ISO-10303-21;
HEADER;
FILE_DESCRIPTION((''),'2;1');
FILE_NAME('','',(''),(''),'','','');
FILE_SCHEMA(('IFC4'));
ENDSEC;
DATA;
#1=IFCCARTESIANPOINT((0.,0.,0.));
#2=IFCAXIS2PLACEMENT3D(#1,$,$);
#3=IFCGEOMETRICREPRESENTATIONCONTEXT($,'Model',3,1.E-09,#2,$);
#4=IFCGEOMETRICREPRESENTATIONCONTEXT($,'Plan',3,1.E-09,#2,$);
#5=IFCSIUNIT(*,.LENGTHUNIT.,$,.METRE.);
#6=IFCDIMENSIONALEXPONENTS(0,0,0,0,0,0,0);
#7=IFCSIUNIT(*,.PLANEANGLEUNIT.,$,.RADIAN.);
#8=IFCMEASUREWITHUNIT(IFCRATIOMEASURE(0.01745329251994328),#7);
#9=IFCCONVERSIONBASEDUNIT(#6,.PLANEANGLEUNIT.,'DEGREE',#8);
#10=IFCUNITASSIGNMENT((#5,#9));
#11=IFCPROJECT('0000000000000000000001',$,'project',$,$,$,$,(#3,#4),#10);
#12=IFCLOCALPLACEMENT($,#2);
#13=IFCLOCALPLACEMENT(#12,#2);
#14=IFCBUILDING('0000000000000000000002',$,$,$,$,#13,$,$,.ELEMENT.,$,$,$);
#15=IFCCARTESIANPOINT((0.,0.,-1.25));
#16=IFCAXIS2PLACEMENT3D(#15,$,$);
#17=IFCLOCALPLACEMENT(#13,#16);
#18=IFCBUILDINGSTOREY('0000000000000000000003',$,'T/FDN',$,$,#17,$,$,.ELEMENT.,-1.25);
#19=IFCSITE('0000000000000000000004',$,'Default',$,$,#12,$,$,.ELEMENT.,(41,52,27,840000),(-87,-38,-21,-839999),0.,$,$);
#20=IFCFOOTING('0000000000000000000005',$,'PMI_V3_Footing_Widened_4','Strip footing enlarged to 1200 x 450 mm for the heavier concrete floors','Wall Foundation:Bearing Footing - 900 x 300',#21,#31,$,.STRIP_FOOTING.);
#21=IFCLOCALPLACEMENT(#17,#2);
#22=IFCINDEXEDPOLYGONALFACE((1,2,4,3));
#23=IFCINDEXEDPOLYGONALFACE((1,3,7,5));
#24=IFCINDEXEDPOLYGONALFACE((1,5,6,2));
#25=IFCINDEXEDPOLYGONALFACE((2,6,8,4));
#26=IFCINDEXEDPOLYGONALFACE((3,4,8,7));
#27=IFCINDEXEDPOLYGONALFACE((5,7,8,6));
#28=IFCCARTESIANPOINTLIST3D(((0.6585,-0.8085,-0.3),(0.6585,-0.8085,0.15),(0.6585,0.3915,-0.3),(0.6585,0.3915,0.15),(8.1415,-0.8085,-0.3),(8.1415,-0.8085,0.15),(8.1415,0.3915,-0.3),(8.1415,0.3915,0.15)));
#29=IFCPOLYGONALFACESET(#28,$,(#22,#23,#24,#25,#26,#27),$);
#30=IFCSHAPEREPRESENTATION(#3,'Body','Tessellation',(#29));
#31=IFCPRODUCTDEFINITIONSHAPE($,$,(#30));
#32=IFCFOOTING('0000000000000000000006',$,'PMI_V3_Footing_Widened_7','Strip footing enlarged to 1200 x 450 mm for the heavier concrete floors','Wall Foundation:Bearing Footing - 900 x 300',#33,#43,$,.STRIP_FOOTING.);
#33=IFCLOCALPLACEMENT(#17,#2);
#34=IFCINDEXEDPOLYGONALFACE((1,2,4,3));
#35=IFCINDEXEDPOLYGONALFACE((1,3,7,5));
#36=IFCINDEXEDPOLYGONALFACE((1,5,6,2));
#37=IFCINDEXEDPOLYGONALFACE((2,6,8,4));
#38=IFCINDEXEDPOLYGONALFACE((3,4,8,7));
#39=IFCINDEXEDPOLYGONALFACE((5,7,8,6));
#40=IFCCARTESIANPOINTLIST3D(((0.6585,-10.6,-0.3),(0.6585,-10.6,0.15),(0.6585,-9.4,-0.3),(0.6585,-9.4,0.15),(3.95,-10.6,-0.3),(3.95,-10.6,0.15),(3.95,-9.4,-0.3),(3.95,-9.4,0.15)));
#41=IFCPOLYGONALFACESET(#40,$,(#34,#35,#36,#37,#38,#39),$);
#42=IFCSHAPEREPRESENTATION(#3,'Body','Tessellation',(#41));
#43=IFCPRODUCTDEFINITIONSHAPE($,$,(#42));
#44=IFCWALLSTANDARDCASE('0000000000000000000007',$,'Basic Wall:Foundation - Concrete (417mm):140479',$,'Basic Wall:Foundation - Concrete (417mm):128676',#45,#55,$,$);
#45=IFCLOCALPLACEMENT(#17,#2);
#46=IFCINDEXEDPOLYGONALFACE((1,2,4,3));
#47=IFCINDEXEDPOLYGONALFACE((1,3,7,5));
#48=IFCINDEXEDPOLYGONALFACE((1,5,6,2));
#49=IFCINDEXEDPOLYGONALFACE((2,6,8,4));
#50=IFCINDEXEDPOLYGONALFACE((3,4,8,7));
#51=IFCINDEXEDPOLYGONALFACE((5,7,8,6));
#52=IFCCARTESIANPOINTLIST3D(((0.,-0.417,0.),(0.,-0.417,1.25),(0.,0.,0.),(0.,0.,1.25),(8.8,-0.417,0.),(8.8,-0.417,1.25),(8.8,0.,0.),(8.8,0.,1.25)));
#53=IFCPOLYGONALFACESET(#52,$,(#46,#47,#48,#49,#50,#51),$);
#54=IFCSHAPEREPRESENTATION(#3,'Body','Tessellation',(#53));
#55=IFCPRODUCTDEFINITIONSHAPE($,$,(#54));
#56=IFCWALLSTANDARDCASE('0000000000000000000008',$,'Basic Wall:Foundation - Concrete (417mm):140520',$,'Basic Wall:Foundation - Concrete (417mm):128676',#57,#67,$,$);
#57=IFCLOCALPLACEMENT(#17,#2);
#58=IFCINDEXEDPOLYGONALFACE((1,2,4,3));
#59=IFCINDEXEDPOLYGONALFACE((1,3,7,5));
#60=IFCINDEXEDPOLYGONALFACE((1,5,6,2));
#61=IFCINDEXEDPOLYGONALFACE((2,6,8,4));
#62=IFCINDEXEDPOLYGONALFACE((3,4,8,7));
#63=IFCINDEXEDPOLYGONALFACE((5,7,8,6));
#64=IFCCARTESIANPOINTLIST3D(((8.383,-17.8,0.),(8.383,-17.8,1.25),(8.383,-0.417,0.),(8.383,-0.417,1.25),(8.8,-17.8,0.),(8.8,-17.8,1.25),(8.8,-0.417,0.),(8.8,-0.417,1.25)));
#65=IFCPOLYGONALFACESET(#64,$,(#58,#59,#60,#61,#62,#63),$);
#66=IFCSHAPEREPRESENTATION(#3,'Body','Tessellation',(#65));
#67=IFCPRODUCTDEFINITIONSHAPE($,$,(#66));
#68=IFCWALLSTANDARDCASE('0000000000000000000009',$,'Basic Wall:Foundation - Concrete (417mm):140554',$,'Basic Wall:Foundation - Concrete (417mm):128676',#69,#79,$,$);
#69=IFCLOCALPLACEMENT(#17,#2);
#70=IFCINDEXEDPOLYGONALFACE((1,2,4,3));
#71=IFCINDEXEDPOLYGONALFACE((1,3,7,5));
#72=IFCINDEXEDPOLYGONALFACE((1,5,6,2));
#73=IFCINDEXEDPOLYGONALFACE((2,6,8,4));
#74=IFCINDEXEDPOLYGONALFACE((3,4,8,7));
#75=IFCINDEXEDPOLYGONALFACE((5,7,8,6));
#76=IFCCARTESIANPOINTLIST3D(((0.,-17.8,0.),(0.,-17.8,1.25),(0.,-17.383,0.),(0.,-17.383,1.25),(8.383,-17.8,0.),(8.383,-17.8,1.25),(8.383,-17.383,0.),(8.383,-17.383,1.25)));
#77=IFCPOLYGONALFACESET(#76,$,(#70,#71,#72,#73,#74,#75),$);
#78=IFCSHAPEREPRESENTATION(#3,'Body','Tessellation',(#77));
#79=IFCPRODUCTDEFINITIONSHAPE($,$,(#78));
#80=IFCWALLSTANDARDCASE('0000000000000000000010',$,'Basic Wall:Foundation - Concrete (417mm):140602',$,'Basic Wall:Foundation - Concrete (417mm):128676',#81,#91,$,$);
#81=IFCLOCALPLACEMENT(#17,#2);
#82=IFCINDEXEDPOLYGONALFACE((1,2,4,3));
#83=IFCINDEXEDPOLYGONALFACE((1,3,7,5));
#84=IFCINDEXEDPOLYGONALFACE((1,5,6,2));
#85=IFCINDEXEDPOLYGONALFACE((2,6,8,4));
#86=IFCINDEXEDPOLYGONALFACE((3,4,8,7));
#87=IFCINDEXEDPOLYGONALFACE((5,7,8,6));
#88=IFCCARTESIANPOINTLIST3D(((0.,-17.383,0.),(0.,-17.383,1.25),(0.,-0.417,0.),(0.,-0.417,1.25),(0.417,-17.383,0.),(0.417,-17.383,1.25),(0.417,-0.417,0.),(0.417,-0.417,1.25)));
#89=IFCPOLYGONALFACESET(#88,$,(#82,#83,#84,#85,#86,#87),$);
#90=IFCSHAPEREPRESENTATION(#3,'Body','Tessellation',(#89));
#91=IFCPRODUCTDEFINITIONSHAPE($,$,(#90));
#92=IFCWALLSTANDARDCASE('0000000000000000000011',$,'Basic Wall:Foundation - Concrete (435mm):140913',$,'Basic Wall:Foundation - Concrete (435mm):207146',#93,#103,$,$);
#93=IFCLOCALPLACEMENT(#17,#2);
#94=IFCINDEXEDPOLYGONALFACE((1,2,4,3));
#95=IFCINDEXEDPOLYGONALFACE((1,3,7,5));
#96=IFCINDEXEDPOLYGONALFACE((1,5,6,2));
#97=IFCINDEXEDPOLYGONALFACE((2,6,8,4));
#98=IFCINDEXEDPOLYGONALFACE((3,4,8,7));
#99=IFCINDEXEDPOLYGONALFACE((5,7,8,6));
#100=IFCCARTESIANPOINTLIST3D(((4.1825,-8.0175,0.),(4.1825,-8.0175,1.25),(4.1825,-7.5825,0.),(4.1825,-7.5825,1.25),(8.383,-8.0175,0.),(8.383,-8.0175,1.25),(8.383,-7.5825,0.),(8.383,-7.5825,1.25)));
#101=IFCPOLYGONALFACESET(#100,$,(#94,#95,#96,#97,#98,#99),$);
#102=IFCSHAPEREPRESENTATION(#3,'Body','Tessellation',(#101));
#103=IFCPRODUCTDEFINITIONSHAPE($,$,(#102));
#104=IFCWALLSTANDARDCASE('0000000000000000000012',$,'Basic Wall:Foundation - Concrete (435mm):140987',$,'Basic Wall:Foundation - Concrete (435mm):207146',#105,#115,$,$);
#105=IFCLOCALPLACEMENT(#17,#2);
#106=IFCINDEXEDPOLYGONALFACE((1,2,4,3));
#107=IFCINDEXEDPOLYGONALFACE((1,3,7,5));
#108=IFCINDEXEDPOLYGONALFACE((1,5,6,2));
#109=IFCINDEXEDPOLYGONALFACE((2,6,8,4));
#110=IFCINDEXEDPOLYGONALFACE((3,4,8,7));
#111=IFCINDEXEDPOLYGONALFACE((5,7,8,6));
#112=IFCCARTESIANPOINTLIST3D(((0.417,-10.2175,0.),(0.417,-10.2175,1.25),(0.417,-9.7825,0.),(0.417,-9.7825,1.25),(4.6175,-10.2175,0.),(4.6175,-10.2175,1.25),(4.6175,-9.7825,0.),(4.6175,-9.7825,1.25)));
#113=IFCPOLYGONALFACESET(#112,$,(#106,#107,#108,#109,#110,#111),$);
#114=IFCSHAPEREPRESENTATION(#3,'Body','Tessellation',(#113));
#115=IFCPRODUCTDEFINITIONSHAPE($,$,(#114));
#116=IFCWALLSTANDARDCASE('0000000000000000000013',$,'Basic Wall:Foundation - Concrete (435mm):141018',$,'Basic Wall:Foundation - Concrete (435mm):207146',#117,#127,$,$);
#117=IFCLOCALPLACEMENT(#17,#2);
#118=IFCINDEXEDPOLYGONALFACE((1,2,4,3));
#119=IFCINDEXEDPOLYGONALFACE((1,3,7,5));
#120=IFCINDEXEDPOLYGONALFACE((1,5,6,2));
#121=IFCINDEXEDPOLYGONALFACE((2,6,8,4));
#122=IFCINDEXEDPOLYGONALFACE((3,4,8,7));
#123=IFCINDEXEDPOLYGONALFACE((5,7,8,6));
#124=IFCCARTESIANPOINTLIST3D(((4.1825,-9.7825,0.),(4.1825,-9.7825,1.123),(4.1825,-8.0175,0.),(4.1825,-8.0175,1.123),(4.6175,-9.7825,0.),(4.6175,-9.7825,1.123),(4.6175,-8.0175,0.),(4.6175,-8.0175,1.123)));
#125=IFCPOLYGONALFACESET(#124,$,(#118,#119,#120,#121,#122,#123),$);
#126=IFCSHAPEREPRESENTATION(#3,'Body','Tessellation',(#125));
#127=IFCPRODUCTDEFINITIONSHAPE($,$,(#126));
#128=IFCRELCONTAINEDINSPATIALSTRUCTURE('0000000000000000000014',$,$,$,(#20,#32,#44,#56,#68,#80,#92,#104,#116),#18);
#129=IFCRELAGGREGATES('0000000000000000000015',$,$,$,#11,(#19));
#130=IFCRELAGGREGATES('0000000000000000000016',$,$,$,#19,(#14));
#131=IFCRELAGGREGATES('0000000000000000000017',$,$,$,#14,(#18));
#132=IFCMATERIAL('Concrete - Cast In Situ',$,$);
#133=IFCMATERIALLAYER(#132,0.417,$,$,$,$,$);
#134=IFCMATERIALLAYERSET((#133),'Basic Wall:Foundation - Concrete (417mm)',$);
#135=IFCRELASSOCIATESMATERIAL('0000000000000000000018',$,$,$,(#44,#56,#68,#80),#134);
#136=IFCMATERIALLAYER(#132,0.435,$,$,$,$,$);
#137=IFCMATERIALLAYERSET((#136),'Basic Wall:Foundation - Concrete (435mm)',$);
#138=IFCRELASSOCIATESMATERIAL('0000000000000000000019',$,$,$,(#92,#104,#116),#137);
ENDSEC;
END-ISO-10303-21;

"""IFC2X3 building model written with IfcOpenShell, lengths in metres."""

from ifc_helpers import new_model, entity, si_unit, converted_unit, frame, frame_2d, origin, origin_2d_with_axis, place, context, project, spatial, rectangle, extrude, material, layer, layer_set, layer_usage, element, save


model = new_model("IFC2X3")

# Units and contexts
model_context = context("Model", 3, precision=1e-09, world=origin())
plan_context = context("Plan", 3, precision=1e-09, world=origin())
ifc_project = project(units=[si_unit("LENGTHUNIT", "METRE"), converted_unit("PLANEANGLEUNIT", "DEGREE", entity("IfcRatioMeasure", 0.01745329251994328), si_unit("PLANEANGLEUNIT", "RADIAN"), dimensions=[0, 0, 0, 0, 0, 0, 0])], contexts=[model_context, plan_context])

# Site, building, storey
site_placement = place(None, origin())
site = spatial("IfcSite", under=ifc_project, at=site_placement, Name="Default", CompositionType="ELEMENT", RefLatitude=(41, 52, 27, 840000), RefLongitude=(-87, -38, -21, -839999), RefElevation=0.0)
building_placement = place(site_placement, origin())
building = spatial("IfcBuilding", under=site, at=building_placement, CompositionType="ELEMENT")
storey_placement = place(building_placement, frame((0.0, 0.0, -1.25)))
storey = spatial("IfcBuildingStorey", under=building, at=storey_placement, Name="T/FDN", CompositionType="ELEMENT", Elevation=-1.25)

# Footings
footing_1_placement = place(storey_placement, origin())
element("IfcFooting", 1, at=footing_1_placement, inside=storey, Name="PMI_V3_Footing_Widened_4", Description="Strip footing enlarged to 1200 x 450 mm for the heavier concrete floors", ObjectType="Wall Foundation:Bearing Footing - 900 x 300", PredefinedType="STRIP_FOOTING", context=model_context, shape_type="SweptSolid", body=[
    extrude(rectangle(XDim=7.483, YDim=1.2, at=origin_2d_with_axis()), frame((4.4, -0.2085, -0.3), z_axis=(0.0, 0.0, 1.0), x_axis=(-1.0, 0.0, 0.0)), (0.0, 0.0, 1.0), 0.45),
])
footing_2_placement = place(storey_placement, origin())
element("IfcFooting", 2, at=footing_2_placement, inside=storey, Name="PMI_V3_Footing_Widened_7", Description="Strip footing enlarged to 1200 x 450 mm for the heavier concrete floors", ObjectType="Wall Foundation:Bearing Footing - 900 x 300", PredefinedType="STRIP_FOOTING", context=model_context, shape_type="SweptSolid", body=[
    extrude(rectangle(XDim=3.2915, YDim=1.2, at=origin_2d_with_axis()), frame((2.3042, -10.0, -0.3)), (0.0, 0.0, 1.0), 0.45),
])

# Walls
ifc_material = material(Name="Concrete - Cast In Situ")
ifc_layer_1 = layer(ifc_material, 0.417)
ifc_layer_set_1 = layer_set([ifc_layer_1], Name="Basic Wall:Foundation - Concrete (417mm)")
ifc_layer_usage_1 = layer_usage(ifc_layer_set_1, "AXIS2", "NEGATIVE", 0.2085)
wall_1_placement = place(storey_placement, frame((0.0, -0.2085, 0.0)))
element("IfcWallStandardCase", 3, at=wall_1_placement, inside=storey, material=ifc_layer_usage_1, Name="Basic Wall:Foundation - Concrete (417mm):140479", ObjectType="Basic Wall:Foundation - Concrete (417mm):128676", context=model_context, shape_type="SweptSolid", body=[
    extrude(rectangle(XDim=8.8, YDim=0.417, at=frame_2d((4.4, 0.0), x_axis=(-1.0, 0.0))), origin(), (0.0, 0.0, 1.0), 1.25),
])
ifc_layer_usage_2 = layer_usage(ifc_layer_set_1, "AXIS2", "NEGATIVE", 0.2085)
wall_2_placement = place(storey_placement, frame((8.5915, -0.417, 0.0), z_axis=(0.0, 0.0, 1.0), x_axis=(0.0, -1.0, 0.0)))
element("IfcWallStandardCase", 4, at=wall_2_placement, inside=storey, material=ifc_layer_usage_2, Name="Basic Wall:Foundation - Concrete (417mm):140520", ObjectType="Basic Wall:Foundation - Concrete (417mm):128676", context=model_context, shape_type="SweptSolid", body=[
    extrude(rectangle(XDim=17.383, YDim=0.417, at=frame_2d((8.6915, 0.0), x_axis=(-1.0, 0.0))), origin(), (0.0, 0.0, 1.0), 1.25),
])
ifc_layer_usage_3 = layer_usage(ifc_layer_set_1, "AXIS2", "NEGATIVE", 0.2085)
wall_3_placement = place(storey_placement, frame((8.383, -17.5915, 0.0), z_axis=(0.0, 0.0, 1.0), x_axis=(-1.0, 0.0, 0.0)))
element("IfcWallStandardCase", 5, at=wall_3_placement, inside=storey, material=ifc_layer_usage_3, Name="Basic Wall:Foundation - Concrete (417mm):140554", ObjectType="Basic Wall:Foundation - Concrete (417mm):128676", context=model_context, shape_type="SweptSolid", body=[
    extrude(rectangle(XDim=8.383, YDim=0.417, at=frame_2d((4.1915, 0.0), x_axis=(-1.0, 0.0))), origin(), (0.0, 0.0, 1.0), 1.25),
])
ifc_layer_usage_4 = layer_usage(ifc_layer_set_1, "AXIS2", "NEGATIVE", 0.2085)
wall_4_placement = place(storey_placement, frame((0.2085, -17.383, 0.0), z_axis=(0.0, 0.0, 1.0), x_axis=(0.0, 1.0, 0.0)))
element("IfcWallStandardCase", 6, at=wall_4_placement, inside=storey, material=ifc_layer_usage_4, Name="Basic Wall:Foundation - Concrete (417mm):140602", ObjectType="Basic Wall:Foundation - Concrete (417mm):128676", context=model_context, shape_type="SweptSolid", body=[
    extrude(rectangle(XDim=16.966, YDim=0.417, at=frame_2d((8.483, 0.0), x_axis=(-1.0, 0.0))), origin(), (0.0, 0.0, 1.0), 1.25),
])
ifc_layer_2 = layer(ifc_material, 0.435)
ifc_layer_set_2 = layer_set([ifc_layer_2], Name="Basic Wall:Foundation - Concrete (435mm)")
ifc_layer_usage_5 = layer_usage(ifc_layer_set_2, "AXIS2", "NEGATIVE", 0.2175)
wall_5_placement = place(storey_placement, frame((8.383, -7.8, 0.0), z_axis=(0.0, 0.0, 1.0), x_axis=(-1.0, 0.0, 0.0)))
element("IfcWallStandardCase", 7, at=wall_5_placement, inside=storey, material=ifc_layer_usage_5, Name="Basic Wall:Foundation - Concrete (435mm):140913", ObjectType="Basic Wall:Foundation - Concrete (435mm):207146", context=model_context, shape_type="SweptSolid", body=[
    extrude(rectangle(XDim=4.2005, YDim=0.435, at=frame_2d((2.1002, 0.0), x_axis=(-1.0, 0.0))), origin(), (0.0, 0.0, 1.0), 1.25),
])
ifc_layer_usage_6 = layer_usage(ifc_layer_set_2, "AXIS2", "NEGATIVE", 0.2175)
wall_6_placement = place(storey_placement, frame((0.417, -10.0, 0.0)))
element("IfcWallStandardCase", 8, at=wall_6_placement, inside=storey, material=ifc_layer_usage_6, Name="Basic Wall:Foundation - Concrete (435mm):140987", ObjectType="Basic Wall:Foundation - Concrete (435mm):207146", context=model_context, shape_type="SweptSolid", body=[
    extrude(rectangle(XDim=4.2005, YDim=0.435, at=frame_2d((2.1002, 0.0), x_axis=(-1.0, 0.0))), origin(), (0.0, 0.0, 1.0), 1.25),
])
ifc_layer_usage_7 = layer_usage(ifc_layer_set_2, "AXIS2", "NEGATIVE", 0.2175)
wall_7_placement = place(storey_placement, frame((4.4, -9.7825, 0.0), z_axis=(0.0, 0.0, 1.0), x_axis=(0.0, 1.0, 0.0)))
element("IfcWallStandardCase", 9, at=wall_7_placement, inside=storey, material=ifc_layer_usage_7, Name="Basic Wall:Foundation - Concrete (435mm):141018", ObjectType="Basic Wall:Foundation - Concrete (435mm):207146", context=model_context, shape_type="SweptSolid", body=[
    extrude(rectangle(XDim=1.765, YDim=0.435, at=frame_2d((0.8825, 0.0), x_axis=(-1.0, 0.0))), origin(), (0.0, 0.0, 1.0), 1.123),
])

save(model, "model.ifc")
